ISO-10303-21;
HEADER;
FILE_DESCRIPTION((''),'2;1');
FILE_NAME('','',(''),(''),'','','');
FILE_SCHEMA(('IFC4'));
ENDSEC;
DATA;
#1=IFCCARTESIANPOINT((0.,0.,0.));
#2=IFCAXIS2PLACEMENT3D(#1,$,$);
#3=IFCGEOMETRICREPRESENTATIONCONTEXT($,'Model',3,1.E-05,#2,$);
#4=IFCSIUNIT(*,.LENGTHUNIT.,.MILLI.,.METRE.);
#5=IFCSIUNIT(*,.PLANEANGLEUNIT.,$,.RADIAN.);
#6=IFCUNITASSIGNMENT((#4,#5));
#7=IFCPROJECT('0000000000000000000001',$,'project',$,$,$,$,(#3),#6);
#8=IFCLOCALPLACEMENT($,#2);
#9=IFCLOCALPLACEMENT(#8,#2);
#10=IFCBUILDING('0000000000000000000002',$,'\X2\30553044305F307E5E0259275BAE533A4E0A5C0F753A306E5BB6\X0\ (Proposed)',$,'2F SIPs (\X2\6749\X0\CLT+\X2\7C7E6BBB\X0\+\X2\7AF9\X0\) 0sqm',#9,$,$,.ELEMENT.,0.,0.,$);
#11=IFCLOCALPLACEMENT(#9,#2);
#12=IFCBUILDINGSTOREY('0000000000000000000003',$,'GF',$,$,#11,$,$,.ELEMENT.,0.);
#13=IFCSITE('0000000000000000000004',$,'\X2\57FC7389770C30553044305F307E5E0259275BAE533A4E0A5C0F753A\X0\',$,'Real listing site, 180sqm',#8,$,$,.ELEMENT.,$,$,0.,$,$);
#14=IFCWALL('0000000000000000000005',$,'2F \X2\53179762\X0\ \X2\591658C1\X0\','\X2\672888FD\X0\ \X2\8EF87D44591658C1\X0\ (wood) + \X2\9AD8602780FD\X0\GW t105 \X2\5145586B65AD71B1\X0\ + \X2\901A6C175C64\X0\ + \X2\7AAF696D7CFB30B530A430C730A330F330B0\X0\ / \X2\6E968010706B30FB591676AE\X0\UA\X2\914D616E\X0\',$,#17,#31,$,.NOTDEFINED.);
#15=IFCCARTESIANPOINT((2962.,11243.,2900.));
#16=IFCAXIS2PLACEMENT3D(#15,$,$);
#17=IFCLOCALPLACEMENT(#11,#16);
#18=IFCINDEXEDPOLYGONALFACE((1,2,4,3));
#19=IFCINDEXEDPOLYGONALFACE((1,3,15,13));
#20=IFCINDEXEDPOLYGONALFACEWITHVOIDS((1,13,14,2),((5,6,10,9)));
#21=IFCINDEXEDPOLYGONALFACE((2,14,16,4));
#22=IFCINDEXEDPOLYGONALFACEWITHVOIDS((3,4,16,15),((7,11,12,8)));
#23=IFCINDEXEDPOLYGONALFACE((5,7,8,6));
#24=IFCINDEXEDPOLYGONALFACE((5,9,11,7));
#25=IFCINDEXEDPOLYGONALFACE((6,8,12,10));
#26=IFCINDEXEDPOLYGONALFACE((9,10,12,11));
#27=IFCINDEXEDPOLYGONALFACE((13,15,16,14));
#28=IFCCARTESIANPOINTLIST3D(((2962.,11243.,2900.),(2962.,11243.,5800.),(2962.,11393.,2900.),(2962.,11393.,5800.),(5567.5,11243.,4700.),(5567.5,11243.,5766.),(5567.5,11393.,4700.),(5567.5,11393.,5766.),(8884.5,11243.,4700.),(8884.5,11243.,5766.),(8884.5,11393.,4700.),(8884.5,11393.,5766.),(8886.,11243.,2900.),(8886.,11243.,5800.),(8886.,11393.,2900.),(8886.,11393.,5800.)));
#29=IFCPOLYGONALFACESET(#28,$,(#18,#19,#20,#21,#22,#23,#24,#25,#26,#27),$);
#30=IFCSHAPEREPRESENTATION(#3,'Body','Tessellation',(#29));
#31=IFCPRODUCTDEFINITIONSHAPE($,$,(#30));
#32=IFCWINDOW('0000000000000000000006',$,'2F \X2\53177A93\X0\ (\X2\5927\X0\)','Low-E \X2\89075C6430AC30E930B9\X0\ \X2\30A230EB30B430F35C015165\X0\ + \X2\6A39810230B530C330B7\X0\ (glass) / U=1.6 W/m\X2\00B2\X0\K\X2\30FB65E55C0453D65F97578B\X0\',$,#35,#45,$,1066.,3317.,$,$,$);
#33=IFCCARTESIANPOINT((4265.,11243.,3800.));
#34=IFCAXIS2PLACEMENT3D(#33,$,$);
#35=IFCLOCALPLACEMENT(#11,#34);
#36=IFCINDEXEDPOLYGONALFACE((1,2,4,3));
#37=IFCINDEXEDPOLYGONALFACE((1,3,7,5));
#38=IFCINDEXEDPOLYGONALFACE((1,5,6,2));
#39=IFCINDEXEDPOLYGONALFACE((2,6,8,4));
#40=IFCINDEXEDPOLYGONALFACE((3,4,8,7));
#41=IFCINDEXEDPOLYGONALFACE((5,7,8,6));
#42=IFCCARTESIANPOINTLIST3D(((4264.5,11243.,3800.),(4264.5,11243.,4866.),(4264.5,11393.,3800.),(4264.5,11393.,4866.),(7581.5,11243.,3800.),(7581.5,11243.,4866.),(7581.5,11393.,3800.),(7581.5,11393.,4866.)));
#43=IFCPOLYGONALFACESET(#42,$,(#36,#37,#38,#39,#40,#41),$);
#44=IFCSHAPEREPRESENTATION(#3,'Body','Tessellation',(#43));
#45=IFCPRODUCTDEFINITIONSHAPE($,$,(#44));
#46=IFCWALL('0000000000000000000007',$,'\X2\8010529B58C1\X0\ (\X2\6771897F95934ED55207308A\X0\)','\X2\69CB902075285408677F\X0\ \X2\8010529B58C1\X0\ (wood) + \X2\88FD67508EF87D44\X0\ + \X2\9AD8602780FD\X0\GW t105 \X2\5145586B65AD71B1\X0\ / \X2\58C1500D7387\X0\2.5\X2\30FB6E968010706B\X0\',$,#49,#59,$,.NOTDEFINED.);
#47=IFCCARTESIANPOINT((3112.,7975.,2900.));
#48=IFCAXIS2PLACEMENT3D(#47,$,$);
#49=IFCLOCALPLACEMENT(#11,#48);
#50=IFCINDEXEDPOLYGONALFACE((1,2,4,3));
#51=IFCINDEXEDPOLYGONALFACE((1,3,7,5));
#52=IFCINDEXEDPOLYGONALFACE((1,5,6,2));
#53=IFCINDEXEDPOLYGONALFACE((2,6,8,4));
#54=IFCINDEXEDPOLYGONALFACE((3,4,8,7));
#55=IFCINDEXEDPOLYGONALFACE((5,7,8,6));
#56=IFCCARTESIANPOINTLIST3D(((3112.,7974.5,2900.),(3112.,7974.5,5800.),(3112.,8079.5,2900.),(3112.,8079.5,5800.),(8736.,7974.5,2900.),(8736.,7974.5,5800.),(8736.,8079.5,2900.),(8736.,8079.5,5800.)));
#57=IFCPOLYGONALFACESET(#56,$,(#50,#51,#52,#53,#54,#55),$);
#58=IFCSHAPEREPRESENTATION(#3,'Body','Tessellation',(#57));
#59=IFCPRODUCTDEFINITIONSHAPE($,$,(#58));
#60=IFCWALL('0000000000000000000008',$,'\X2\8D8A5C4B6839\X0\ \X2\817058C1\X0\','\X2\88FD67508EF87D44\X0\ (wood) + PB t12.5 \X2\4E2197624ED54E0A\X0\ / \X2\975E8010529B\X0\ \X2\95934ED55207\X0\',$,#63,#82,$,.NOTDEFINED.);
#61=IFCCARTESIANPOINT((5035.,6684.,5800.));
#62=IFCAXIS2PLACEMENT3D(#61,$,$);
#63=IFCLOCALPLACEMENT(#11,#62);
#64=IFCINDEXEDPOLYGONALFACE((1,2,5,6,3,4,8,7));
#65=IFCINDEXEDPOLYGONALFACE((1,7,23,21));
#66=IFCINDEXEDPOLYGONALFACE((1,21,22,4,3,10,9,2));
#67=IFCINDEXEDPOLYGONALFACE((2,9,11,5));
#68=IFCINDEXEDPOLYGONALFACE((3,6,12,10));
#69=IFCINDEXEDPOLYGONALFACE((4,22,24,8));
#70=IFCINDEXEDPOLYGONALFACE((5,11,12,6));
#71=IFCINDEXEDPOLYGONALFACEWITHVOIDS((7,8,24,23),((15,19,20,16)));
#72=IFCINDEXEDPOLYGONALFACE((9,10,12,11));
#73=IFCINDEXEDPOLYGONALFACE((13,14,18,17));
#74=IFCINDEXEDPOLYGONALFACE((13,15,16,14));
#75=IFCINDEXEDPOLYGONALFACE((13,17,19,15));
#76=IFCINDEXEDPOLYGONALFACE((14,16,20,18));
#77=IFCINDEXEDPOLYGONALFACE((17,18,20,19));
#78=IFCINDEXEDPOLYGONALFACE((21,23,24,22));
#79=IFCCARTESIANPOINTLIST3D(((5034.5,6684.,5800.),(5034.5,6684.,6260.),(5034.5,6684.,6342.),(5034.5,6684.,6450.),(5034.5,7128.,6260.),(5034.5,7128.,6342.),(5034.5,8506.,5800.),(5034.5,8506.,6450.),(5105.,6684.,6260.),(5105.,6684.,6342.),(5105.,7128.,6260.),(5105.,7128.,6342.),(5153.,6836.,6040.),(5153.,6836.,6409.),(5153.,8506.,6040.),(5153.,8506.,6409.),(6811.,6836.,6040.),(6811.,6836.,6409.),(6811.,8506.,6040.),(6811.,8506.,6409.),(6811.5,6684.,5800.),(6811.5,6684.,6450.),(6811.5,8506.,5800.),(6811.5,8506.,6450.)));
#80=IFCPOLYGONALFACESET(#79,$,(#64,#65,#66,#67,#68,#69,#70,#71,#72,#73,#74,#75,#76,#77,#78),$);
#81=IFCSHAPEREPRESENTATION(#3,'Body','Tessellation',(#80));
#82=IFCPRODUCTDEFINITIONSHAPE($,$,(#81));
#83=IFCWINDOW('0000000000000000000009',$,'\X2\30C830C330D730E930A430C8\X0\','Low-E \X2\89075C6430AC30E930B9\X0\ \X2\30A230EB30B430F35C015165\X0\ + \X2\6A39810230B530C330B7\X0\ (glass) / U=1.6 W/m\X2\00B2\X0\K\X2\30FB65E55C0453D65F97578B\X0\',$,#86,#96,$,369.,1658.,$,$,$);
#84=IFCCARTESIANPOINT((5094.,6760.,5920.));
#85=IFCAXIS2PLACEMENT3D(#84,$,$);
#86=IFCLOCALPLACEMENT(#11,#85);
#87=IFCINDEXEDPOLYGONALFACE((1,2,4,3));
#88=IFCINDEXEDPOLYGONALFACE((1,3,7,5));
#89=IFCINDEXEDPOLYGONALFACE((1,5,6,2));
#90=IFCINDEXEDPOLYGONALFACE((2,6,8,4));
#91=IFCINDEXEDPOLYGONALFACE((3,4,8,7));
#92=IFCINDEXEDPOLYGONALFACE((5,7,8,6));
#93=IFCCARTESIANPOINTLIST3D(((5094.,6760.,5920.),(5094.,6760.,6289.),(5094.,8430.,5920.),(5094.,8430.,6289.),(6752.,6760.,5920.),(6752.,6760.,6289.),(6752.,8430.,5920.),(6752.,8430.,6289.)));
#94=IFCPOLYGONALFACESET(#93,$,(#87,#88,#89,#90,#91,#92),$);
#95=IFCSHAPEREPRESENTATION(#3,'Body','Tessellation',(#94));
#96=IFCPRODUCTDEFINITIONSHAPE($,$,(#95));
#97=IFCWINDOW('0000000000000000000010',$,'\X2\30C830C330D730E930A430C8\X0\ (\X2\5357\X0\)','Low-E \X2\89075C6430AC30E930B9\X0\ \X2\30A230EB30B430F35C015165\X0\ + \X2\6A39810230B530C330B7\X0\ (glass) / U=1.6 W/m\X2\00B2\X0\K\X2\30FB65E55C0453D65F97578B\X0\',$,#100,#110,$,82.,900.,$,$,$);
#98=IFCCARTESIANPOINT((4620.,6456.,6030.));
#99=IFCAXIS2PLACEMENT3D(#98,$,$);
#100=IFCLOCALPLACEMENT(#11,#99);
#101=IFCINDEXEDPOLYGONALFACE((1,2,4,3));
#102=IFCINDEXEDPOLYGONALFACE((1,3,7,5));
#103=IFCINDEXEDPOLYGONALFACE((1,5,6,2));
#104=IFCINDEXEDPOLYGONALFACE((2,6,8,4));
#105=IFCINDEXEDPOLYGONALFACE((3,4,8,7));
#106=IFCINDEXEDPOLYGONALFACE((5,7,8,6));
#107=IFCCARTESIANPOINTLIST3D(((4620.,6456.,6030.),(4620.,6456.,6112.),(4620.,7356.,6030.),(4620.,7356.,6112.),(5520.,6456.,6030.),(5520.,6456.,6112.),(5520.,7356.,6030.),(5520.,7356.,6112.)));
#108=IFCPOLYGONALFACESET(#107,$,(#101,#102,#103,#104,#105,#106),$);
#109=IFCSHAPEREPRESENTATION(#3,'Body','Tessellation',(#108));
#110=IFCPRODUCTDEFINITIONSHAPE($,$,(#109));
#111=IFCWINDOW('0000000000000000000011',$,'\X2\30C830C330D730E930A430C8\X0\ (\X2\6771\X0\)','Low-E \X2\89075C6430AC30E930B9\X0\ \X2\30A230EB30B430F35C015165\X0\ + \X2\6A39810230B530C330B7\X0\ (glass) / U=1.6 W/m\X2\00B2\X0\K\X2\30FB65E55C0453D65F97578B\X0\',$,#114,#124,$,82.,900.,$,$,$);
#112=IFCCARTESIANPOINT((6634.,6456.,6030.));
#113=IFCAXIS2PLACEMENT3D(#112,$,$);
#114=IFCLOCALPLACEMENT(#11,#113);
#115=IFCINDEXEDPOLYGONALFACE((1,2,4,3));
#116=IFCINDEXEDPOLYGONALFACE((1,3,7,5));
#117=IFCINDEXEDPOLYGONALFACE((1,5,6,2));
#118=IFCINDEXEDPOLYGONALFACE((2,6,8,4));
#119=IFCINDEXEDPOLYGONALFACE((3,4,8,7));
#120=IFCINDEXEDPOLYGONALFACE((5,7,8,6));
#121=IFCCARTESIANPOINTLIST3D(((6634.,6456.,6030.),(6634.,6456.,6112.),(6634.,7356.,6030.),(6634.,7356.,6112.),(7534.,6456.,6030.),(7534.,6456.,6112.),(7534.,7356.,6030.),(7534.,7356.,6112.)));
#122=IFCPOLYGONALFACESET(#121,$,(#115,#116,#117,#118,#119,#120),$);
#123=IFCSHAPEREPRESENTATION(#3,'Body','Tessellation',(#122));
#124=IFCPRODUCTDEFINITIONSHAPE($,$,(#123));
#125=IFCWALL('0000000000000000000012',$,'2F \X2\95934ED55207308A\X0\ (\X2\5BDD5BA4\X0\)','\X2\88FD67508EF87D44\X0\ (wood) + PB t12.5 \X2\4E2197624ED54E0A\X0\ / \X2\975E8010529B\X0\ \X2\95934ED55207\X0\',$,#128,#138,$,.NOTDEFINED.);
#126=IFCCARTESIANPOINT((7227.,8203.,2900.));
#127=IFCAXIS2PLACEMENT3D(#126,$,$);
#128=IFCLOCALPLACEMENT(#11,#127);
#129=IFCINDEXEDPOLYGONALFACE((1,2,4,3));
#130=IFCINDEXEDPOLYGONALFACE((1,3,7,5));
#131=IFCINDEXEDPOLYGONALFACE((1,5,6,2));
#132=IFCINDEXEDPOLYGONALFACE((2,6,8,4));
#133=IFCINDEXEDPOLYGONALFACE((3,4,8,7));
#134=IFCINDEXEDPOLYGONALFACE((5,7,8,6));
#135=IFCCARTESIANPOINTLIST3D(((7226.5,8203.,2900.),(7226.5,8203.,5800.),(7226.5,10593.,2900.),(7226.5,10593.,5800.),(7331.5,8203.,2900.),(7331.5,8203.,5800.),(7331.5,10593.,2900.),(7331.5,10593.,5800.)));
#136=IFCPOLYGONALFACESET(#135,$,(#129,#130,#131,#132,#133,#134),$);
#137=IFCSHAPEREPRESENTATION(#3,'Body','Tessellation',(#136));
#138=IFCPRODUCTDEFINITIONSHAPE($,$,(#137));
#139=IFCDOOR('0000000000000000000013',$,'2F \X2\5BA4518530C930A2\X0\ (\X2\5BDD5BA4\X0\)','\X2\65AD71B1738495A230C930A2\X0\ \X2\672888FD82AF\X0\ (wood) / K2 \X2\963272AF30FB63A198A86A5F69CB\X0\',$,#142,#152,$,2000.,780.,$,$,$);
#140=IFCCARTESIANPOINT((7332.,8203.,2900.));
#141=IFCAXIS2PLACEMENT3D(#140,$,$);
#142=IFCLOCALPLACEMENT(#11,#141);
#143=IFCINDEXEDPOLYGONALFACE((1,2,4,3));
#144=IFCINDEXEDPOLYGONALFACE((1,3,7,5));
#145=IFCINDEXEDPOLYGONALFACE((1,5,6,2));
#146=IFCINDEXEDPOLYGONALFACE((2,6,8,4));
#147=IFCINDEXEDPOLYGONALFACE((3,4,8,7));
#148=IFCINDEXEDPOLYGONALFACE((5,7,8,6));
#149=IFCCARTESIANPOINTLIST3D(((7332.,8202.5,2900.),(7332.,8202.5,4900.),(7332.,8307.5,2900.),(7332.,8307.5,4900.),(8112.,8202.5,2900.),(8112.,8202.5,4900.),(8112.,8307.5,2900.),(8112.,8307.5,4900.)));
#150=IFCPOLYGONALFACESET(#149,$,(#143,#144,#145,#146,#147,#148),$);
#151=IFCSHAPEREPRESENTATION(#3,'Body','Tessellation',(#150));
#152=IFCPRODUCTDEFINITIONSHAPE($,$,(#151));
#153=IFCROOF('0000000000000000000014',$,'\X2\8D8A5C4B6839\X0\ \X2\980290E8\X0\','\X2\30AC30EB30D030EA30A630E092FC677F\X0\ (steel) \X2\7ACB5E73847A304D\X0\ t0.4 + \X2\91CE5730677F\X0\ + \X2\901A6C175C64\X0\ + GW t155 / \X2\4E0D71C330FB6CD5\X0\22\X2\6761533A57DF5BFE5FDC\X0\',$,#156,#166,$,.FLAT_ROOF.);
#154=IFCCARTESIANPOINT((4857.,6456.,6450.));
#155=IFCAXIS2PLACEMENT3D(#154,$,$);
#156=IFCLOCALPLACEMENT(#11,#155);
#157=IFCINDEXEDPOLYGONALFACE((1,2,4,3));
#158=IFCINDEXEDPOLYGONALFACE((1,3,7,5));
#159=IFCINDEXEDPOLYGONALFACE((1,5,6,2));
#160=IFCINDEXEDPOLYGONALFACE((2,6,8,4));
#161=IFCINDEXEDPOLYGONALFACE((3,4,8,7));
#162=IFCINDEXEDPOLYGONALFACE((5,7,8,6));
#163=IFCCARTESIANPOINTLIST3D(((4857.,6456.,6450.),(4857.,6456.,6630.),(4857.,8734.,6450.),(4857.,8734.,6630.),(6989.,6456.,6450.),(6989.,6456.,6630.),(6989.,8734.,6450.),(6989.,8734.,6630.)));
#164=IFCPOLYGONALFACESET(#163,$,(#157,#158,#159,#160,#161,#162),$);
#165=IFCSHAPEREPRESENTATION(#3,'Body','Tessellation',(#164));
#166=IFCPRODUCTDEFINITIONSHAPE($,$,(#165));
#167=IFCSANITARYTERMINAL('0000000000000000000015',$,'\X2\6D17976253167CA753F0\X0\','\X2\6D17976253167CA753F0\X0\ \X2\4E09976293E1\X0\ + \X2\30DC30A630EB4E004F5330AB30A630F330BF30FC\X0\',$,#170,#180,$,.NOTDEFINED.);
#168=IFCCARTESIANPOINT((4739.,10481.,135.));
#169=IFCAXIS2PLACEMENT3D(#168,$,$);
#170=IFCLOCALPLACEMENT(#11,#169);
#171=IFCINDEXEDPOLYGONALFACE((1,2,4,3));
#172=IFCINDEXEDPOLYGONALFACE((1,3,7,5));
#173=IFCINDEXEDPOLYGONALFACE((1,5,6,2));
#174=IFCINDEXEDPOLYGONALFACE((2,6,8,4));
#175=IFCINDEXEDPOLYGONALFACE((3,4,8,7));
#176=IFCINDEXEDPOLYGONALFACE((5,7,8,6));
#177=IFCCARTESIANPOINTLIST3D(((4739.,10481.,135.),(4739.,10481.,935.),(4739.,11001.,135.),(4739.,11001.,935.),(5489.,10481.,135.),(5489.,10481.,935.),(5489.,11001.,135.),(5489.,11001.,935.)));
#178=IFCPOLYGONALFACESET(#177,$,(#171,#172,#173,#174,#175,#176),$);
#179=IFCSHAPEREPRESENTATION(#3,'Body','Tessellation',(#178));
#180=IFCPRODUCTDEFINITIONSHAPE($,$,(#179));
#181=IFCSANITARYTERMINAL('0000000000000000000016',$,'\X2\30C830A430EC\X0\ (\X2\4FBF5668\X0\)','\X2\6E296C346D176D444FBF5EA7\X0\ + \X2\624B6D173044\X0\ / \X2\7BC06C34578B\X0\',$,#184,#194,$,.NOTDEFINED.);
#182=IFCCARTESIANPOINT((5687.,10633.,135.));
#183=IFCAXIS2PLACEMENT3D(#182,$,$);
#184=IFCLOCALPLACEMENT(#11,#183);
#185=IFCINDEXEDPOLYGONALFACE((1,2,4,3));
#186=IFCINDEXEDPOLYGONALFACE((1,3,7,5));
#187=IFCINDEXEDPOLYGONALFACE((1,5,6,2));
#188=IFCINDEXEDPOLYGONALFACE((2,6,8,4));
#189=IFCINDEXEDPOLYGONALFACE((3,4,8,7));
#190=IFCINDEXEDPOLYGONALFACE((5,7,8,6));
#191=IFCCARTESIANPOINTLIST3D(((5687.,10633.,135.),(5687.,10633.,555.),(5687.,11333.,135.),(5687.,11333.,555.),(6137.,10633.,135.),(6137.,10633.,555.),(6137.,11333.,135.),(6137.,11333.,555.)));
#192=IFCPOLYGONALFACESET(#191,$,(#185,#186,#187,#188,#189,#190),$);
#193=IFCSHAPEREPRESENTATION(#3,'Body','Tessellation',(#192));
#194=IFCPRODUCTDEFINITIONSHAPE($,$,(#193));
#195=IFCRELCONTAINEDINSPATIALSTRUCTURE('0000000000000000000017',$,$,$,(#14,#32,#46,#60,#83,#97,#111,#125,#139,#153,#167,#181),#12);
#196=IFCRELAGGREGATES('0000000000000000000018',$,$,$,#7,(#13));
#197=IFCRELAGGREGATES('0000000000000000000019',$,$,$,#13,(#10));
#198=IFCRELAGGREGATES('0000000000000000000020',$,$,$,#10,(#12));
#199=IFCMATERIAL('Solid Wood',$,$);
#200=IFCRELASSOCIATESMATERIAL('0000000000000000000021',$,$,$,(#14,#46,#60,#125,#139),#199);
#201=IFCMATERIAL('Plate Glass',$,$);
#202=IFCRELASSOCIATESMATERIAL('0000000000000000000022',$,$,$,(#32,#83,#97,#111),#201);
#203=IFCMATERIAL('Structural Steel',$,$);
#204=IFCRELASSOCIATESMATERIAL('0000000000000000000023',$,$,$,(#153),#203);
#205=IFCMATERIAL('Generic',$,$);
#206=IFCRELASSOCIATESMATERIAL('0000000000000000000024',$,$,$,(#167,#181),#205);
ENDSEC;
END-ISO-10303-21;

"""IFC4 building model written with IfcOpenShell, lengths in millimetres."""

from ifc_helpers import new_model, si_unit, frame, frame_2d, origin, place, context, project, spatial, rectangle, extrude, material, element, fill, save


model = new_model("IFC4")

# Units and contexts
model_context = context("Model", 3, precision=1e-05, world=origin())
ifc_project = project(units=[si_unit("LENGTHUNIT", "METRE", prefix="MILLI"), si_unit("PLANEANGLEUNIT", "RADIAN")], contexts=[model_context])

# Site, building, storey
site_placement = place(None, origin())
site = spatial("IfcSite", under=ifc_project, at=site_placement, Name="埼玉県さいたま市大宮区上小町", ObjectType="Real listing site, 180sqm", CompositionType="ELEMENT", RefElevation=0.0)
building_placement = place(site_placement, origin())
building = spatial("IfcBuilding", under=site, at=building_placement, Name="さいたま市大宮区上小町の家 (Proposed)", ObjectType="2F SIPs (杉CLT+籾殻+竹) 0sqm", CompositionType="ELEMENT", ElevationOfRefHeight=0.0, ElevationOfTerrain=0.0)
storey_placement = place(building_placement, origin())
storey = spatial("IfcBuildingStorey", under=building, at=storey_placement, Name="GF", CompositionType="ELEMENT", Elevation=0.0)

# Wall, opening, window
ifc_material_1 = material(Name="Solid Wood")
wall_1_placement = place(storey_placement, frame((2962.0, 11243.0, 2900.0)))
wall_1 = element("IfcWall", 1, at=wall_1_placement, inside=storey, material=ifc_material_1, Name="2F 北面 外壁", Description="木製 軸組外壁 (wood) + 高性能GW t105 充填断熱 + 通気層 + 窯業系サイディング / 準耐火・外皮UA配慮", PredefinedType="NOTDEFINED", context=model_context, shape_type="SweptSolid", body=[
    extrude(rectangle(XDim=5924.0, YDim=150.0, at=frame_2d((2962.0, 75.0))), frame((2962.0, 11243.0, 2900.0)), (0.0, 0.0, 1.0), 2900.0),
])
opening_1_placement = place(storey_placement, frame((4265.0, 11243.0, 3800.0)))
opening_1 = element("IfcOpeningElement", 2, at=opening_1_placement, cuts=wall_1, PredefinedType="NOTDEFINED", context=model_context, shape_type="SweptSolid", body=[
    extrude(rectangle(XDim=3317.0, YDim=150.0, at=frame_2d((1658.0, 75.0))), frame((4265.0, 11243.0, 3800.0)), (0.0, 0.0, 1.0), 1066.0),
])
ifc_material_2 = material(Name="Plate Glass")
window_1_placement = place(storey_placement, frame((4265.0, 11243.0, 3800.0)))
window_1 = element("IfcWindow", 3, at=window_1_placement, inside=storey, material=ifc_material_2, Name="2F 北窓 (大)", Description="Low-E 複層ガラス アルゴン封入 + 樹脂サッシ (glass) / U=1.6 W/m²K・日射取得型", OverallHeight=1066.0, OverallWidth=3317.0, context=model_context, shape_type="SweptSolid", body=[
    extrude(rectangle(XDim=3317.0, YDim=150.0, at=frame_2d((1658.0, 75.0))), frame((4265.0, 11243.0, 3800.0)), (0.0, 0.0, 1.0), 1066.0),
])
fill(opening_1, window_1)

# Wall
wall_2_placement = place(storey_placement, frame((3112.0, 7975.0, 2900.0)))
element("IfcWall", 4, at=wall_2_placement, inside=storey, material=ifc_material_1, Name="耐力壁 (東西間仕切り)", Description="構造用合板 耐力壁 (wood) + 製材軸組 + 高性能GW t105 充填断熱 / 壁倍率2.5・準耐火", PredefinedType="NOTDEFINED", context=model_context, shape_type="SweptSolid", body=[
    extrude(rectangle(XDim=5624.0, YDim=105.0, at=frame_2d((2812.0, 52.0))), frame((3112.0, 7975.0, 2900.0)), (0.0, 0.0, 1.0), 2900.0),
])

# Wall, openings, windows
wall_3_placement = place(storey_placement, frame((5035.0, 6684.0, 5800.0)))
wall_3 = element("IfcWall", 5, at=wall_3_placement, inside=storey, material=ifc_material_1, Name="越屋根 腰壁", Description="製材軸組 (wood) + PB t12.5 両面仕上 / 非耐力 間仕切", PredefinedType="NOTDEFINED", context=model_context, shape_type="SweptSolid", body=[
    extrude(rectangle(XDim=1777.0, YDim=1822.0, at=frame_2d((888.0, 911.0))), frame((5035.0, 6684.0, 5800.0)), (0.0, 0.0, 1.0), 650.0),
])
opening_2_placement = place(storey_placement, frame((5094.0, 6760.0, 5920.0)))
opening_2 = element("IfcOpeningElement", 6, at=opening_2_placement, cuts=wall_3, PredefinedType="NOTDEFINED", context=model_context, shape_type="SweptSolid", body=[
    extrude(rectangle(XDim=1658.0, YDim=1670.0, at=frame_2d((829.0, 835.0))), frame((5094.0, 6760.0, 5920.0)), (0.0, 0.0, 1.0), 369.0),
])
opening_3_placement = place(storey_placement, frame((4620.0, 6456.0, 6030.0)))
opening_3 = element("IfcOpeningElement", 7, at=opening_3_placement, cuts=wall_3, PredefinedType="NOTDEFINED", context=model_context, shape_type="SweptSolid", body=[
    extrude(rectangle(XDim=900.0, YDim=900.0, at=frame_2d((450.0, 450.0))), frame((4620.0, 6456.0, 6030.0)), (0.0, 0.0, 1.0), 82.0),
])
opening_4_placement = place(storey_placement, frame((6634.0, 6456.0, 6030.0)))
opening_4 = element("IfcOpeningElement", 8, at=opening_4_placement, cuts=wall_3, PredefinedType="NOTDEFINED", context=model_context, shape_type="SweptSolid", body=[
    extrude(rectangle(XDim=900.0, YDim=900.0, at=frame_2d((450.0, 450.0))), frame((6634.0, 6456.0, 6030.0)), (0.0, 0.0, 1.0), 82.0),
])
window_2_placement = place(storey_placement, frame((5094.0, 6760.0, 5920.0)))
window_2 = element("IfcWindow", 9, at=window_2_placement, inside=storey, material=ifc_material_2, Name="トップライト", Description="Low-E 複層ガラス アルゴン封入 + 樹脂サッシ (glass) / U=1.6 W/m²K・日射取得型", OverallHeight=369.0, OverallWidth=1658.0, context=model_context, shape_type="SweptSolid", body=[
    extrude(rectangle(XDim=1658.0, YDim=1670.0, at=frame_2d((829.0, 835.0))), frame((5094.0, 6760.0, 5920.0)), (0.0, 0.0, 1.0), 369.0),
])
fill(opening_2, window_2)
window_3_placement = place(storey_placement, frame((4620.0, 6456.0, 6030.0)))
window_3 = element("IfcWindow", 10, at=window_3_placement, inside=storey, material=ifc_material_2, Name="トップライト (南)", Description="Low-E 複層ガラス アルゴン封入 + 樹脂サッシ (glass) / U=1.6 W/m²K・日射取得型", OverallHeight=82.0, OverallWidth=900.0, context=model_context, shape_type="SweptSolid", body=[
    extrude(rectangle(XDim=900.0, YDim=900.0, at=frame_2d((450.0, 450.0))), frame((4620.0, 6456.0, 6030.0)), (0.0, 0.0, 1.0), 82.0),
])
fill(opening_3, window_3)
window_4_placement = place(storey_placement, frame((6634.0, 6456.0, 6030.0)))
window_4 = element("IfcWindow", 11, at=window_4_placement, inside=storey, material=ifc_material_2, Name="トップライト (東)", Description="Low-E 複層ガラス アルゴン封入 + 樹脂サッシ (glass) / U=1.6 W/m²K・日射取得型", OverallHeight=82.0, OverallWidth=900.0, context=model_context, shape_type="SweptSolid", body=[
    extrude(rectangle(XDim=900.0, YDim=900.0, at=frame_2d((450.0, 450.0))), frame((6634.0, 6456.0, 6030.0)), (0.0, 0.0, 1.0), 82.0),
])
fill(opening_4, window_4)

# Wall
wall_4_placement = place(storey_placement, frame((7227.0, 8203.0, 2900.0)))
element("IfcWall", 12, at=wall_4_placement, inside=storey, material=ifc_material_1, Name="2F 間仕切り (寝室)", Description="製材軸組 (wood) + PB t12.5 両面仕上 / 非耐力 間仕切", PredefinedType="NOTDEFINED", context=model_context, shape_type="SweptSolid", body=[
    extrude(rectangle(XDim=105.0, YDim=2390.0, at=frame_2d((52.0, 1195.0))), frame((7227.0, 8203.0, 2900.0)), (0.0, 0.0, 1.0), 2900.0),
])

# Door
door_placement = place(storey_placement, frame((7332.0, 8203.0, 2900.0)))
element("IfcDoor", 13, at=door_placement, inside=storey, material=ifc_material_1, Name="2F 室内ドア (寝室)", Description="断熱玄関ドア 木製芯 (wood) / K2 防犯・採風機構", OverallHeight=2000.0, OverallWidth=780.0, context=model_context, shape_type="SweptSolid", body=[
    extrude(rectangle(XDim=780.0, YDim=105.0, at=frame_2d((390.0, 52.0))), frame((7332.0, 8203.0, 2900.0)), (0.0, 0.0, 1.0), 2000.0),
])

# Roof
ifc_material_3 = material(Name="Structural Steel")
roof_placement = place(storey_placement, frame((4857.0, 6456.0, 6450.0)))
element("IfcRoof", 14, at=roof_placement, inside=storey, material=ifc_material_3, Name="越屋根 頂部", Description="ガルバリウム鋼板 (steel) 立平葺き t0.4 + 野地板 + 通気層 + GW t155 / 不燃・法22条区域対応", PredefinedType="FLAT_ROOF", context=model_context, shape_type="SweptSolid", body=[
    extrude(rectangle(XDim=2132.0, YDim=2278.0, at=frame_2d((1066.0, 1139.0))), frame((4857.0, 6456.0, 6450.0)), (0.0, 0.0, 1.0), 180.0),
])

# Sanitary terminals
ifc_material_4 = material(Name="Generic")
sanitary_terminal_1_placement = place(storey_placement, frame((4739.0, 10481.0, 135.0)))
element("IfcSanitaryTerminal", 15, at=sanitary_terminal_1_placement, inside=storey, material=ifc_material_4, Name="洗面化粧台", Description="洗面化粧台 三面鏡 + ボウル一体カウンター", PredefinedType="NOTDEFINED", context=model_context, shape_type="SweptSolid", body=[
    extrude(rectangle(XDim=750.0, YDim=520.0, at=frame_2d((375.0, 260.0))), frame((4739.0, 10481.0, 135.0)), (0.0, 0.0, 1.0), 800.0),
])
sanitary_terminal_2_placement = place(storey_placement, frame((5687.0, 10633.0, 135.0)))
element("IfcSanitaryTerminal", 16, at=sanitary_terminal_2_placement, inside=storey, material=ifc_material_4, Name="トイレ (便器)", Description="温水洗浄便座 + 手洗い / 節水型", PredefinedType="NOTDEFINED", context=model_context, shape_type="SweptSolid", body=[
    extrude(rectangle(XDim=450.0, YDim=700.0, at=frame_2d((225.0, 350.0))), frame((5687.0, 10633.0, 135.0)), (0.0, 0.0, 1.0), 420.0),
])

save(model, "model.ifc")
